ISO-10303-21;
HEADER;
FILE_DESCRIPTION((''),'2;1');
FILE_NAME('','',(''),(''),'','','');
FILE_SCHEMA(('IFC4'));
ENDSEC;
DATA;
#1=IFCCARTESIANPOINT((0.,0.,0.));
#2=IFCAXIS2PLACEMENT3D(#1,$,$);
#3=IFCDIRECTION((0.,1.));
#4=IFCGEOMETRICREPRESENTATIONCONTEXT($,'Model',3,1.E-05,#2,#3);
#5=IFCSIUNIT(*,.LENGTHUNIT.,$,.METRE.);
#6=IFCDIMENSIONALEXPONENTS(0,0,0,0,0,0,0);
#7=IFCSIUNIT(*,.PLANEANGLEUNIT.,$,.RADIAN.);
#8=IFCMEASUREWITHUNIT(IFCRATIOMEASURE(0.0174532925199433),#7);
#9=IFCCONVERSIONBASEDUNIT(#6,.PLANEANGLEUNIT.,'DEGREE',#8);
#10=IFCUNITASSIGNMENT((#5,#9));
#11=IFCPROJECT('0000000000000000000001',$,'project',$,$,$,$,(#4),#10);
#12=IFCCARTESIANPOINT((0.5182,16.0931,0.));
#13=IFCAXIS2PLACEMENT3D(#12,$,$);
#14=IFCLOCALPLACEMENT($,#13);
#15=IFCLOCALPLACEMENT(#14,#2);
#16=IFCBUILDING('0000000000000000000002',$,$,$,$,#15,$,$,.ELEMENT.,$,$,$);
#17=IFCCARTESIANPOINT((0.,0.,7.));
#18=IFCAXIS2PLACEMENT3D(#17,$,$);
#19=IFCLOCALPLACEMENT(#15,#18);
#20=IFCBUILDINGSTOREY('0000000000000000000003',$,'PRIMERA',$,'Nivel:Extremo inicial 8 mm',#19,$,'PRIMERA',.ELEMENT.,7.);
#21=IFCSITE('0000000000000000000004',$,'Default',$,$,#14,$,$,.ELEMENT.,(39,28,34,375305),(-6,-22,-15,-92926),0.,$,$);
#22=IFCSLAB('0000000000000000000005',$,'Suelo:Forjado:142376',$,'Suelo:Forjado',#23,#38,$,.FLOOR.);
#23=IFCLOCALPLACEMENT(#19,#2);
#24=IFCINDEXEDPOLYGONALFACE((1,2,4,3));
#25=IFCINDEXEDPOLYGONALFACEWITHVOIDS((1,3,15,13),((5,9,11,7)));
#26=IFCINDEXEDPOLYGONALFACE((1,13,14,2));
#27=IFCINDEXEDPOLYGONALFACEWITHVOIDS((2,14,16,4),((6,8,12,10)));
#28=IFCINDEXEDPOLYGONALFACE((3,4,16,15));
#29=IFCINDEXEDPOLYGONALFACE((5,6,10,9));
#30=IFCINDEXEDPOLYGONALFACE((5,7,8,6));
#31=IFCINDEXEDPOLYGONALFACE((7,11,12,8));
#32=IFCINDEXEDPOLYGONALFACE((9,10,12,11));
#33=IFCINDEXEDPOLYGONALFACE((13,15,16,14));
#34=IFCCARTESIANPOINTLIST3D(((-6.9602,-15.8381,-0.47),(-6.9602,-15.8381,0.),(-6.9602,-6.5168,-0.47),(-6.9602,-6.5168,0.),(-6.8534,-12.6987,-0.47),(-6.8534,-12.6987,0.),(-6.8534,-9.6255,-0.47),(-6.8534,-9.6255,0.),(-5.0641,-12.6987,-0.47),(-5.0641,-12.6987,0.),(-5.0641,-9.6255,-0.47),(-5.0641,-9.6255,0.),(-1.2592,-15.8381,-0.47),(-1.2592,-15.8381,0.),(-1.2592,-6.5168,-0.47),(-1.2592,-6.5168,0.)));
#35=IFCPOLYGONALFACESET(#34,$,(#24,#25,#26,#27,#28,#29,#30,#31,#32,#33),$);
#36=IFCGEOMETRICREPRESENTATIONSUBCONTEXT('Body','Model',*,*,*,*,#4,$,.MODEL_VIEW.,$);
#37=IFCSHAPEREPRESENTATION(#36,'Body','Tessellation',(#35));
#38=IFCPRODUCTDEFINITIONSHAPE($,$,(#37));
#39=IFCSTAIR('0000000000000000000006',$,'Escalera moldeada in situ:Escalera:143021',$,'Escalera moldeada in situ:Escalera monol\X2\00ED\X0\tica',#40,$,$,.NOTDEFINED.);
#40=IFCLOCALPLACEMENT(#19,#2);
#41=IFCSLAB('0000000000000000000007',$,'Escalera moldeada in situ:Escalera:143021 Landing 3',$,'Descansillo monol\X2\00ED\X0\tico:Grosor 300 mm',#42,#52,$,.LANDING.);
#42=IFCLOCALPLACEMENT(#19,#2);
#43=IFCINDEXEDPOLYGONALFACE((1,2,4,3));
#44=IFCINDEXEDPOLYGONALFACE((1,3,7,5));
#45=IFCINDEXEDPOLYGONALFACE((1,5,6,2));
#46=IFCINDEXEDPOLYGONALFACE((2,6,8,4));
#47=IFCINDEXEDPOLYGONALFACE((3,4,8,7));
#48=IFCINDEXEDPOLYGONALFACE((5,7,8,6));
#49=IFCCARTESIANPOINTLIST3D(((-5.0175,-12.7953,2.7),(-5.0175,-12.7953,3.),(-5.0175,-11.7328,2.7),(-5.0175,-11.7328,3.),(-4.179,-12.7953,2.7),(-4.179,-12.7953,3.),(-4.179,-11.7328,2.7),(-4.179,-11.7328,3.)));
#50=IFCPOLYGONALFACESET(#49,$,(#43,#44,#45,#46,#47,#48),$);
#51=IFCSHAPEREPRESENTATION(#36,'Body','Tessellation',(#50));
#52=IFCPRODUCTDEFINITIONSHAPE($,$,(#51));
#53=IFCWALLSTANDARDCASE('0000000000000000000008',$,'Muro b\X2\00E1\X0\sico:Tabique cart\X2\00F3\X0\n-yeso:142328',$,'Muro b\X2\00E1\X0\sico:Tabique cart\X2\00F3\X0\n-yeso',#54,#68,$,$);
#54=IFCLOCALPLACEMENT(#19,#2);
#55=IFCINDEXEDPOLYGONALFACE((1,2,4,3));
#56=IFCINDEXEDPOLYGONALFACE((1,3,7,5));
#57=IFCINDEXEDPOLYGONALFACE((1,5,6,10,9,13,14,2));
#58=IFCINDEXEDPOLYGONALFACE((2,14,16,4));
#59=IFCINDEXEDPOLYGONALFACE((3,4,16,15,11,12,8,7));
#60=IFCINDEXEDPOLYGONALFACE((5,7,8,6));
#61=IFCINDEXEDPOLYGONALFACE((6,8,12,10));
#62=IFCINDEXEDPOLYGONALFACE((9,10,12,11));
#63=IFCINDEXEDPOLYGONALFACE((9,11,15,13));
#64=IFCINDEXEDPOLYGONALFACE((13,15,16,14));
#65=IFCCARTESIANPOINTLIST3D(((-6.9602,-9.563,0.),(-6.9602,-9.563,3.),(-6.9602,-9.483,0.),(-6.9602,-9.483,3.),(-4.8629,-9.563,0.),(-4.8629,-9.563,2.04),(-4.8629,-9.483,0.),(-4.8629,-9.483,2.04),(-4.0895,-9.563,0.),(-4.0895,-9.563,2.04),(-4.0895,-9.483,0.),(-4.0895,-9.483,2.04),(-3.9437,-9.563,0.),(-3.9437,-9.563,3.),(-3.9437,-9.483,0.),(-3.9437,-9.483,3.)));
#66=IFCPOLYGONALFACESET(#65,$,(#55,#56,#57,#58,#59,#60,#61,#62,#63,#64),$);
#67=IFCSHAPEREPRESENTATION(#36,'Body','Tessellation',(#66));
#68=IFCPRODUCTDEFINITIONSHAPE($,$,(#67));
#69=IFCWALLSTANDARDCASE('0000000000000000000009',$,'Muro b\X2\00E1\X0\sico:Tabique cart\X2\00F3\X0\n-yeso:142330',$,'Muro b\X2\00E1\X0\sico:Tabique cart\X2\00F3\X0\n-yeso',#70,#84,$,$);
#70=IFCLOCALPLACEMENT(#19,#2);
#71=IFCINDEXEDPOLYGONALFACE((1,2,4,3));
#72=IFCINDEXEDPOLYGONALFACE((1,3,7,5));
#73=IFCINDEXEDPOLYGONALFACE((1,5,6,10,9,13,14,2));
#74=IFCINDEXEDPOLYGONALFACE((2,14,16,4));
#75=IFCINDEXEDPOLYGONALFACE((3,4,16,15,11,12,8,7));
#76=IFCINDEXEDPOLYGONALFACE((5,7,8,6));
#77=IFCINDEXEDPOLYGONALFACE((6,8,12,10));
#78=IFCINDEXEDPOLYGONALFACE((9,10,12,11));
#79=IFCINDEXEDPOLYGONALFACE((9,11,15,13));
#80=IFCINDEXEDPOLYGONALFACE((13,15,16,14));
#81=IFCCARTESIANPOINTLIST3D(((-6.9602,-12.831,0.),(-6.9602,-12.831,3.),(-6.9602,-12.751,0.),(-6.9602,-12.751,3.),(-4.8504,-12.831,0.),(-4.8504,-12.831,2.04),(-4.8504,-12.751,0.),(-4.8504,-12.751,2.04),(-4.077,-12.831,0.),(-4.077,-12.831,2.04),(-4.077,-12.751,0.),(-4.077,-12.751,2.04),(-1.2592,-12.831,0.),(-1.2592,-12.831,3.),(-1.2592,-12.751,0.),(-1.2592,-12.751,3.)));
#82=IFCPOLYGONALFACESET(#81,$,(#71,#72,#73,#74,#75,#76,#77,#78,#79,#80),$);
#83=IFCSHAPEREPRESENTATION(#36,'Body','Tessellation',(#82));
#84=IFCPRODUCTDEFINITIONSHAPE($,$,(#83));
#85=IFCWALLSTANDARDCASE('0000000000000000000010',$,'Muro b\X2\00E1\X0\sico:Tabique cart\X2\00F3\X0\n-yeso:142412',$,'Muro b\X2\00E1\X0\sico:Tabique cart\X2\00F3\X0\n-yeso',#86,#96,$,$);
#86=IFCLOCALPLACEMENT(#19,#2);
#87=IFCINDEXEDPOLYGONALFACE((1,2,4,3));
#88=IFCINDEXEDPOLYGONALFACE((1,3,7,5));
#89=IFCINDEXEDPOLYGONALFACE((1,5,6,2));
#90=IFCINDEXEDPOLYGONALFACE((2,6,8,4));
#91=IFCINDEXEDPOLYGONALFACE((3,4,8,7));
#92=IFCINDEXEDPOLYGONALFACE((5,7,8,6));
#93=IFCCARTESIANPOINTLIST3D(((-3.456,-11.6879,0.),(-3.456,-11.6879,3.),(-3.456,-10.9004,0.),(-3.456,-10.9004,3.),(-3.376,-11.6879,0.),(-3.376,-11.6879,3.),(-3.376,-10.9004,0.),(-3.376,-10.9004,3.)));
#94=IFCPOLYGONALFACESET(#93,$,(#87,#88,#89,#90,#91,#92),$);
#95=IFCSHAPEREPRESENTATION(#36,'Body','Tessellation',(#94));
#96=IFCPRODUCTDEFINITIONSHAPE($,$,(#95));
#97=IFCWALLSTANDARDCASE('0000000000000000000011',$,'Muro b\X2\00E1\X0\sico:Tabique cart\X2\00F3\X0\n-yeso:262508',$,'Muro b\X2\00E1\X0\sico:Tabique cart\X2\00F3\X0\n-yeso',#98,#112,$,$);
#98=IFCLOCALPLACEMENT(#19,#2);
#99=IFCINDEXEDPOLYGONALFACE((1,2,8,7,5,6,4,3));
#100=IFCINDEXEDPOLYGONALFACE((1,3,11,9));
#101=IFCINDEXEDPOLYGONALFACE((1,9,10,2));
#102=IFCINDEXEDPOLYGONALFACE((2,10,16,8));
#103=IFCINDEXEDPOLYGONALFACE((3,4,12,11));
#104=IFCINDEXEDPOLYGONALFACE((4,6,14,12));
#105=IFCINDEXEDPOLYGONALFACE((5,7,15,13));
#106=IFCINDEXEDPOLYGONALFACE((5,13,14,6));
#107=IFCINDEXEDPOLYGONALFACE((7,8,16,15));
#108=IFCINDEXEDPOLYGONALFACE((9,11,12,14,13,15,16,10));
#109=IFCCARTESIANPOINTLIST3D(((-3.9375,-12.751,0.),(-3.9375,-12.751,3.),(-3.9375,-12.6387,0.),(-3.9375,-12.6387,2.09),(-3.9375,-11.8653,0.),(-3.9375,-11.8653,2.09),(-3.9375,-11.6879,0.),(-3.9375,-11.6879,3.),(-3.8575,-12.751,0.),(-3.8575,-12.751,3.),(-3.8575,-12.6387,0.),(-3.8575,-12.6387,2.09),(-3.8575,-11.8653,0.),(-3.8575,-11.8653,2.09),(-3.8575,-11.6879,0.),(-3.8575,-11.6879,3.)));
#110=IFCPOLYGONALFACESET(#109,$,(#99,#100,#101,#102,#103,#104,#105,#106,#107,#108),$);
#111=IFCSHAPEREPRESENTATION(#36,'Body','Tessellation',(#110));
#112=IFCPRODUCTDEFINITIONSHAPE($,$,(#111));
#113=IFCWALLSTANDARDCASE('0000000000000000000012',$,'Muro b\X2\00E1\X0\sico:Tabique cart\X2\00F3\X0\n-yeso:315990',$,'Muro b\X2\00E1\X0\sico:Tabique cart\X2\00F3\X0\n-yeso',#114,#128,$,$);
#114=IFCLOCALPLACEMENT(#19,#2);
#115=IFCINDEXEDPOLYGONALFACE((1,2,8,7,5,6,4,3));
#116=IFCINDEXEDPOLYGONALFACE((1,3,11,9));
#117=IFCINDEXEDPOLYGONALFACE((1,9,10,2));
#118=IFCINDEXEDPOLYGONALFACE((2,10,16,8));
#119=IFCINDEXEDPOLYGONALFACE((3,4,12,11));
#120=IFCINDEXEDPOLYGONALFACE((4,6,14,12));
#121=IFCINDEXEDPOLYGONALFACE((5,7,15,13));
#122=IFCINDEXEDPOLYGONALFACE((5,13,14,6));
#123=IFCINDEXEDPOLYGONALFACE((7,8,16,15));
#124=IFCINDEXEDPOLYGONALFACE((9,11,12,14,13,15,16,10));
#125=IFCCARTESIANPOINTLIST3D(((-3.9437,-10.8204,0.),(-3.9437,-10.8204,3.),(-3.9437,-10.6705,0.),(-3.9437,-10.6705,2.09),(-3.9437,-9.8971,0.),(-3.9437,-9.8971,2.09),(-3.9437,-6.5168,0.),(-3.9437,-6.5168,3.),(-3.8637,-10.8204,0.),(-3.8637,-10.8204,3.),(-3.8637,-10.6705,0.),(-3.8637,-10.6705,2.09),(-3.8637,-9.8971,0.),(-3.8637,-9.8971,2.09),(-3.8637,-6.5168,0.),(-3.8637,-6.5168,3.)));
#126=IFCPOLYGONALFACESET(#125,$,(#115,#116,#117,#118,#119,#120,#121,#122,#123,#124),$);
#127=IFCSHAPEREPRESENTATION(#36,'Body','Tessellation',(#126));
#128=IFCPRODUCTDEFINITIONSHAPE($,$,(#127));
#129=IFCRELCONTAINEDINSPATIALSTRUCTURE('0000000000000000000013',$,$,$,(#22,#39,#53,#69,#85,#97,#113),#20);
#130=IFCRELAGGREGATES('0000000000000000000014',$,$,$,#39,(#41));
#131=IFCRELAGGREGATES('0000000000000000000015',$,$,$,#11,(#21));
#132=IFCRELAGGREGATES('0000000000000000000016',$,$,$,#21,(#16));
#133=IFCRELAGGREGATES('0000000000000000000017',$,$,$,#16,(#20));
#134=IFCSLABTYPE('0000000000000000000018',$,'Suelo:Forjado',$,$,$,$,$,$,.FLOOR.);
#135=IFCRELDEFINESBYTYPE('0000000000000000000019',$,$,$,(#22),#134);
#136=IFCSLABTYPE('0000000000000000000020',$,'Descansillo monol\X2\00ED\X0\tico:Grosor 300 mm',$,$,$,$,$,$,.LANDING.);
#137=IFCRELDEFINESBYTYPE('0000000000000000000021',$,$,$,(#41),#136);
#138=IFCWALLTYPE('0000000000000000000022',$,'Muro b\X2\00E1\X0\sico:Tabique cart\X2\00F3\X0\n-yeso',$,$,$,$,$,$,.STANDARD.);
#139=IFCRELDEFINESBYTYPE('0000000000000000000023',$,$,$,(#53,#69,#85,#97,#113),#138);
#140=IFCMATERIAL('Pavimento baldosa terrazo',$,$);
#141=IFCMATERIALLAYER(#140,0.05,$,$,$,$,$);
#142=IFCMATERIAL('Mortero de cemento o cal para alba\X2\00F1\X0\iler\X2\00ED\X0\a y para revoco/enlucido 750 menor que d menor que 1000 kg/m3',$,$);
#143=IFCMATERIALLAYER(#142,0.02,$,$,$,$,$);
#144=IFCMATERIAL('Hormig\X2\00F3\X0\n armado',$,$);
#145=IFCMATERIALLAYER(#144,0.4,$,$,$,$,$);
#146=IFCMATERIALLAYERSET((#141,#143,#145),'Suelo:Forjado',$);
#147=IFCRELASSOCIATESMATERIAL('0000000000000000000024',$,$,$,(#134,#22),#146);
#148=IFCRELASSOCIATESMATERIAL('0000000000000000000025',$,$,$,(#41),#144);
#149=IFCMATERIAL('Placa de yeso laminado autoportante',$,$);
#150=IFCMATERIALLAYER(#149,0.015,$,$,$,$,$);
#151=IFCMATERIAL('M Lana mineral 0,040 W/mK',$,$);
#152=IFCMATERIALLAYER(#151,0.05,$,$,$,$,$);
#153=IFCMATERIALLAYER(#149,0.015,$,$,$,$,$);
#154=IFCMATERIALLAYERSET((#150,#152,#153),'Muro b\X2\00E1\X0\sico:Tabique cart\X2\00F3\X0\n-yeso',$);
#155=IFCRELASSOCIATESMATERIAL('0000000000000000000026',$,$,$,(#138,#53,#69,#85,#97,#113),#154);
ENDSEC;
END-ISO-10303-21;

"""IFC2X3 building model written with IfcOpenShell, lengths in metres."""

from ifc_helpers import new_model, entity, si_unit, converted_unit, direction, frame, frame_2d, origin, origin_2d_with_axis, place, context, subcontext, project, spatial, rectangle, extrude, material, layer, layer_set, layer_usage, type_object, element, aggregate, save


model = new_model("IFC2X3")

# Units and contexts
model_context = context("Model", 3, precision=1e-05, world=origin(), true_north=direction((0.0, 1.0)))
body_context = subcontext(model_context, "Body", "Model", "MODEL_VIEW")
ifc_project = project(units=[si_unit("LENGTHUNIT", "METRE"), converted_unit("PLANEANGLEUNIT", "DEGREE", entity("IfcRatioMeasure", 0.0174532925199433), si_unit("PLANEANGLEUNIT", "RADIAN"), dimensions=[0, 0, 0, 0, 0, 0, 0])], contexts=[model_context])

# Site, building, storey
site_placement = place(None, frame((0.5182, 16.0931, 0.0)))
site = spatial("IfcSite", under=ifc_project, at=site_placement, Name="Default", CompositionType="ELEMENT", RefLatitude=(39, 28, 34, 375305), RefLongitude=(-6, -22, -15, -92926), RefElevation=0.0)
building_placement = place(site_placement, origin())
building = spatial("IfcBuilding", under=site, at=building_placement, CompositionType="ELEMENT")
storey_placement = place(building_placement, frame((0.0, 0.0, 7.0)))
storey = spatial("IfcBuildingStorey", under=building, at=storey_placement, Name="PRIMERA", ObjectType="Nivel:Extremo inicial 8 mm", LongName="PRIMERA", CompositionType="ELEMENT", Elevation=7.0)

# Slab, opening
ifc_material_1 = material(Name="Pavimento baldosa terrazo")
ifc_layer_1 = layer(ifc_material_1, 0.05)
ifc_material_2 = material(Name="Mortero de cemento o cal para albañilería y para revoco/enlucido 750 menor que d menor que 1000 kg/m3")
ifc_layer_2 = layer(ifc_material_2, 0.02)
ifc_material_3 = material(Name="Hormigón armado")
ifc_layer_3 = layer(ifc_material_3, 0.4)
ifc_layer_set_1 = layer_set([ifc_layer_1, ifc_layer_2, ifc_layer_3], Name="Suelo:Forjado")
ifc_layer_usage_1 = layer_usage(ifc_layer_set_1, "AXIS3", "POSITIVE", 0.0)
slab_type_1 = type_object("IfcSlabType", Name="Suelo:Forjado", PredefinedType="FLOOR", material=ifc_layer_set_1)
slab_1_placement = place(storey_placement, frame((-6.9602, -15.8381, -0.47)))
slab_1 = element("IfcSlab", 1, at=slab_1_placement, inside=storey, type_object=slab_type_1, material=ifc_layer_usage_1, Name="Suelo:Forjado:142376", ObjectType="Suelo:Forjado", PredefinedType="FLOOR", context=body_context, shape_type="SweptSolid", body=[
    extrude(rectangle(XDim=9.3214, YDim=5.7011, at=frame_2d((0.0, 0.0), x_axis=(0.0, -1.0))), frame((2.8505, 4.6607, 0.47), z_axis=(0.0, 0.0, -1.0), x_axis=(-1.0, 0.0, 0.0)), (0.0, 0.0, 1.0), 0.47),
])
opening_1_placement = place(slab_1_placement, frame((1.0015, 4.676, 0.47)))
element("IfcOpeningElement", 2, at=opening_1_placement, cuts=slab_1, ObjectType="Opening", context=body_context, shape_type="SweptSolid", body=[
    extrude(rectangle(XDim=3.0733, YDim=1.7893, at=origin_2d_with_axis()), frame((0.0, 0.0, 0.0), z_axis=(0.0, 0.0, -1.0), x_axis=(0.0, -1.0, 0.0)), (0.0, 0.0, 1.0), 0.47),
])

# Stair, slab
stair_placement = place(storey_placement, origin())
stair = element("IfcStair", 3, at=stair_placement, inside=storey, Name="Escalera moldeada in situ:Escalera:143021", ObjectType="Escalera moldeada in situ:Escalera monolítica", ShapeType="NOTDEFINED")
slab_type_2 = type_object("IfcSlabType", Name="Descansillo monolítico:Grosor 300 mm", PredefinedType="LANDING")
slab_2_placement = place(stair_placement, origin())
slab_2 = element("IfcSlab", 4, at=slab_2_placement, type_object=slab_type_2, material=ifc_material_3, Name="Escalera moldeada in situ:Escalera:143021 Landing 3", ObjectType="Descansillo monolítico:Grosor 300 mm", PredefinedType="LANDING", context=body_context, shape_type="SweptSolid", body=[
    extrude(rectangle(XDim=0.8385, YDim=1.0625, at=frame_2d((0.0, 0.0), x_axis=(1.0, 0.0))), frame((-4.5982, -12.264, 2.7), z_axis=(0.0, 0.0, 1.0), x_axis=(-1.0, 0.0, 0.0)), (0.0, 0.0, 1.0), 0.3),
])
aggregate(stair, [slab_2])

# Walls, openings
ifc_material_4 = material(Name="Placa de yeso laminado autoportante")
ifc_layer_4 = layer(ifc_material_4, 0.015)
ifc_material_5 = material(Name="M Lana mineral 0,040 W/mK")
ifc_layer_5 = layer(ifc_material_5, 0.05)
ifc_layer_6 = layer(ifc_material_4, 0.015)
ifc_layer_set_2 = layer_set([ifc_layer_4, ifc_layer_5, ifc_layer_6], Name="Muro básico:Tabique cartón-yeso")
ifc_layer_usage_2 = layer_usage(ifc_layer_set_2, "AXIS2", "NEGATIVE", 0.04)
wall_type = type_object("IfcWallType", Name="Muro básico:Tabique cartón-yeso", PredefinedType="STANDARD", material=ifc_layer_set_2)
wall_1_placement = place(storey_placement, frame((-6.9602, -9.523, 0.0)))
wall_1 = element("IfcWallStandardCase", 5, at=wall_1_placement, inside=storey, type_object=wall_type, material=ifc_layer_usage_2, Name="Muro básico:Tabique cartón-yeso:142328", ObjectType="Muro básico:Tabique cartón-yeso", context=body_context, shape_type="SweptSolid", body=[
    extrude(rectangle(XDim=3.0166, YDim=0.08, at=frame_2d((1.5083, 0.0), x_axis=(-1.0, 0.0))), origin(), (0.0, 0.0, 1.0), 3.0),
])
opening_2_placement = place(wall_1_placement, frame((6.9602, 9.523, -3.0)))
element("IfcOpeningElement", 6, at=opening_2_placement, cuts=wall_1, ObjectType="Opening", context=body_context, shape_type="SweptSolid", body=[
    extrude(rectangle(XDim=2.09, YDim=0.7734, at=frame_2d((0.0, 0.0), x_axis=(1.0, 0.0))), frame((-4.4762, -9.713, 3.995), z_axis=(0.0, 1.0, 0.0), x_axis=(0.0, 0.0, -1.0)), (0.0, 0.0, 1.0), 0.23),
])
ifc_layer_usage_3 = layer_usage(ifc_layer_set_2, "AXIS2", "NEGATIVE", 0.04)
wall_2_placement = place(storey_placement, frame((-1.2592, -12.791, 0.0), z_axis=(0.0, 0.0, 1.0), x_axis=(-1.0, 0.0, 0.0)))
wall_2 = element("IfcWallStandardCase", 7, at=wall_2_placement, inside=storey, type_object=wall_type, material=ifc_layer_usage_3, Name="Muro básico:Tabique cartón-yeso:142330", ObjectType="Muro básico:Tabique cartón-yeso", context=body_context, shape_type="SweptSolid", body=[
    extrude(rectangle(XDim=5.7011, YDim=0.08, at=frame_2d((2.8505, 0.0), x_axis=(-1.0, 0.0))), origin(), (0.0, 0.0, 1.0), 3.0),
])
opening_3_placement = place(wall_2_placement, frame((-1.2592, -12.791, -3.0), z_axis=(0.0, 0.0, 1.0), x_axis=(-1.0, 0.0, 0.0)))
element("IfcOpeningElement", 8, at=opening_3_placement, cuts=wall_2, ObjectType="Opening", context=body_context, shape_type="SweptSolid", body=[
    extrude(rectangle(XDim=2.09, YDim=0.7734, at=frame_2d((0.0, 0.0), x_axis=(0.0, 1.0))), frame((-4.4637, -12.601, 3.995), z_axis=(0.0, -1.0, 0.0), x_axis=(-1.0, 0.0, 0.0)), (0.0, 0.0, 1.0), 0.23),
])

# Wall
ifc_layer_usage_4 = layer_usage(ifc_layer_set_2, "AXIS2", "NEGATIVE", 0.04)
wall_3_placement = place(storey_placement, frame((-3.416, -11.6879, 0.0), z_axis=(0.0, 0.0, 1.0), x_axis=(0.0, 1.0, 0.0)))
element("IfcWallStandardCase", 9, at=wall_3_placement, inside=storey, type_object=wall_type, material=ifc_layer_usage_4, Name="Muro básico:Tabique cartón-yeso:142412", ObjectType="Muro básico:Tabique cartón-yeso", context=body_context, shape_type="SweptSolid", body=[
    extrude(rectangle(XDim=0.7875, YDim=0.08, at=frame_2d((0.3938, 0.0), x_axis=(-1.0, 0.0))), origin(), (0.0, 0.0, 1.0), 3.0),
])

# Walls, openings
ifc_layer_usage_5 = layer_usage(ifc_layer_set_2, "AXIS2", "NEGATIVE", 0.04)
wall_4_placement = place(storey_placement, frame((-3.8975, -12.751, 0.0), z_axis=(0.0, 0.0, 1.0), x_axis=(0.0, 1.0, 0.0)))
wall_4 = element("IfcWallStandardCase", 10, at=wall_4_placement, inside=storey, type_object=wall_type, material=ifc_layer_usage_5, Name="Muro básico:Tabique cartón-yeso:262508", ObjectType="Muro básico:Tabique cartón-yeso", context=body_context, shape_type="SweptSolid", body=[
    extrude(rectangle(XDim=1.063, YDim=0.08, at=frame_2d((0.5315, 0.0), x_axis=(-1.0, 0.0))), origin(), (0.0, 0.0, 1.0), 3.0),
])
opening_4_placement = place(wall_4_placement, frame((12.751, -3.8975, 0.0), z_axis=(0.0, 0.0, 1.0), x_axis=(0.0, -1.0, 0.0)))
element("IfcOpeningElement", 11, at=opening_4_placement, cuts=wall_4, ObjectType="Opening", context=body_context, shape_type="SweptSolid", body=[
    extrude(rectangle(XDim=2.09, YDim=0.7734, at=frame_2d((0.0, 0.0), x_axis=(0.0, 1.0))), frame((-3.8575, -12.252, 1.045), z_axis=(-1.0, 0.0, 0.0), x_axis=(0.0, 1.0, 0.0)), (0.0, 0.0, 1.0), 0.23),
])
ifc_layer_usage_6 = layer_usage(ifc_layer_set_2, "AXIS2", "NEGATIVE", 0.04)
wall_5_placement = place(storey_placement, frame((-3.9037, -10.8204, 0.0), z_axis=(0.0, 0.0, 1.0), x_axis=(0.0, 1.0, 0.0)))
wall_5 = element("IfcWallStandardCase", 12, at=wall_5_placement, inside=storey, type_object=wall_type, material=ifc_layer_usage_6, Name="Muro básico:Tabique cartón-yeso:315990", ObjectType="Muro básico:Tabique cartón-yeso", context=body_context, shape_type="SweptSolid", body=[
    extrude(rectangle(XDim=4.3036, YDim=0.08, at=frame_2d((2.1518, 0.0), x_axis=(-1.0, 0.0))), origin(), (0.0, 0.0, 1.0), 3.0),
])
opening_5_placement = place(wall_5_placement, frame((10.8204, -3.9037, 0.0), z_axis=(0.0, 0.0, 1.0), x_axis=(0.0, -1.0, 0.0)))
element("IfcOpeningElement", 13, at=opening_5_placement, cuts=wall_5, ObjectType="Opening", context=body_context, shape_type="SweptSolid", body=[
    extrude(rectangle(XDim=2.09, YDim=0.7734, at=frame_2d((0.0, 0.0), x_axis=(0.0, 1.0))), frame((-3.8637, -10.2838, 1.045), z_axis=(-1.0, 0.0, 0.0), x_axis=(0.0, 1.0, 0.0)), (0.0, 0.0, 1.0), 0.23),
])

save(model, "model.ifc")
